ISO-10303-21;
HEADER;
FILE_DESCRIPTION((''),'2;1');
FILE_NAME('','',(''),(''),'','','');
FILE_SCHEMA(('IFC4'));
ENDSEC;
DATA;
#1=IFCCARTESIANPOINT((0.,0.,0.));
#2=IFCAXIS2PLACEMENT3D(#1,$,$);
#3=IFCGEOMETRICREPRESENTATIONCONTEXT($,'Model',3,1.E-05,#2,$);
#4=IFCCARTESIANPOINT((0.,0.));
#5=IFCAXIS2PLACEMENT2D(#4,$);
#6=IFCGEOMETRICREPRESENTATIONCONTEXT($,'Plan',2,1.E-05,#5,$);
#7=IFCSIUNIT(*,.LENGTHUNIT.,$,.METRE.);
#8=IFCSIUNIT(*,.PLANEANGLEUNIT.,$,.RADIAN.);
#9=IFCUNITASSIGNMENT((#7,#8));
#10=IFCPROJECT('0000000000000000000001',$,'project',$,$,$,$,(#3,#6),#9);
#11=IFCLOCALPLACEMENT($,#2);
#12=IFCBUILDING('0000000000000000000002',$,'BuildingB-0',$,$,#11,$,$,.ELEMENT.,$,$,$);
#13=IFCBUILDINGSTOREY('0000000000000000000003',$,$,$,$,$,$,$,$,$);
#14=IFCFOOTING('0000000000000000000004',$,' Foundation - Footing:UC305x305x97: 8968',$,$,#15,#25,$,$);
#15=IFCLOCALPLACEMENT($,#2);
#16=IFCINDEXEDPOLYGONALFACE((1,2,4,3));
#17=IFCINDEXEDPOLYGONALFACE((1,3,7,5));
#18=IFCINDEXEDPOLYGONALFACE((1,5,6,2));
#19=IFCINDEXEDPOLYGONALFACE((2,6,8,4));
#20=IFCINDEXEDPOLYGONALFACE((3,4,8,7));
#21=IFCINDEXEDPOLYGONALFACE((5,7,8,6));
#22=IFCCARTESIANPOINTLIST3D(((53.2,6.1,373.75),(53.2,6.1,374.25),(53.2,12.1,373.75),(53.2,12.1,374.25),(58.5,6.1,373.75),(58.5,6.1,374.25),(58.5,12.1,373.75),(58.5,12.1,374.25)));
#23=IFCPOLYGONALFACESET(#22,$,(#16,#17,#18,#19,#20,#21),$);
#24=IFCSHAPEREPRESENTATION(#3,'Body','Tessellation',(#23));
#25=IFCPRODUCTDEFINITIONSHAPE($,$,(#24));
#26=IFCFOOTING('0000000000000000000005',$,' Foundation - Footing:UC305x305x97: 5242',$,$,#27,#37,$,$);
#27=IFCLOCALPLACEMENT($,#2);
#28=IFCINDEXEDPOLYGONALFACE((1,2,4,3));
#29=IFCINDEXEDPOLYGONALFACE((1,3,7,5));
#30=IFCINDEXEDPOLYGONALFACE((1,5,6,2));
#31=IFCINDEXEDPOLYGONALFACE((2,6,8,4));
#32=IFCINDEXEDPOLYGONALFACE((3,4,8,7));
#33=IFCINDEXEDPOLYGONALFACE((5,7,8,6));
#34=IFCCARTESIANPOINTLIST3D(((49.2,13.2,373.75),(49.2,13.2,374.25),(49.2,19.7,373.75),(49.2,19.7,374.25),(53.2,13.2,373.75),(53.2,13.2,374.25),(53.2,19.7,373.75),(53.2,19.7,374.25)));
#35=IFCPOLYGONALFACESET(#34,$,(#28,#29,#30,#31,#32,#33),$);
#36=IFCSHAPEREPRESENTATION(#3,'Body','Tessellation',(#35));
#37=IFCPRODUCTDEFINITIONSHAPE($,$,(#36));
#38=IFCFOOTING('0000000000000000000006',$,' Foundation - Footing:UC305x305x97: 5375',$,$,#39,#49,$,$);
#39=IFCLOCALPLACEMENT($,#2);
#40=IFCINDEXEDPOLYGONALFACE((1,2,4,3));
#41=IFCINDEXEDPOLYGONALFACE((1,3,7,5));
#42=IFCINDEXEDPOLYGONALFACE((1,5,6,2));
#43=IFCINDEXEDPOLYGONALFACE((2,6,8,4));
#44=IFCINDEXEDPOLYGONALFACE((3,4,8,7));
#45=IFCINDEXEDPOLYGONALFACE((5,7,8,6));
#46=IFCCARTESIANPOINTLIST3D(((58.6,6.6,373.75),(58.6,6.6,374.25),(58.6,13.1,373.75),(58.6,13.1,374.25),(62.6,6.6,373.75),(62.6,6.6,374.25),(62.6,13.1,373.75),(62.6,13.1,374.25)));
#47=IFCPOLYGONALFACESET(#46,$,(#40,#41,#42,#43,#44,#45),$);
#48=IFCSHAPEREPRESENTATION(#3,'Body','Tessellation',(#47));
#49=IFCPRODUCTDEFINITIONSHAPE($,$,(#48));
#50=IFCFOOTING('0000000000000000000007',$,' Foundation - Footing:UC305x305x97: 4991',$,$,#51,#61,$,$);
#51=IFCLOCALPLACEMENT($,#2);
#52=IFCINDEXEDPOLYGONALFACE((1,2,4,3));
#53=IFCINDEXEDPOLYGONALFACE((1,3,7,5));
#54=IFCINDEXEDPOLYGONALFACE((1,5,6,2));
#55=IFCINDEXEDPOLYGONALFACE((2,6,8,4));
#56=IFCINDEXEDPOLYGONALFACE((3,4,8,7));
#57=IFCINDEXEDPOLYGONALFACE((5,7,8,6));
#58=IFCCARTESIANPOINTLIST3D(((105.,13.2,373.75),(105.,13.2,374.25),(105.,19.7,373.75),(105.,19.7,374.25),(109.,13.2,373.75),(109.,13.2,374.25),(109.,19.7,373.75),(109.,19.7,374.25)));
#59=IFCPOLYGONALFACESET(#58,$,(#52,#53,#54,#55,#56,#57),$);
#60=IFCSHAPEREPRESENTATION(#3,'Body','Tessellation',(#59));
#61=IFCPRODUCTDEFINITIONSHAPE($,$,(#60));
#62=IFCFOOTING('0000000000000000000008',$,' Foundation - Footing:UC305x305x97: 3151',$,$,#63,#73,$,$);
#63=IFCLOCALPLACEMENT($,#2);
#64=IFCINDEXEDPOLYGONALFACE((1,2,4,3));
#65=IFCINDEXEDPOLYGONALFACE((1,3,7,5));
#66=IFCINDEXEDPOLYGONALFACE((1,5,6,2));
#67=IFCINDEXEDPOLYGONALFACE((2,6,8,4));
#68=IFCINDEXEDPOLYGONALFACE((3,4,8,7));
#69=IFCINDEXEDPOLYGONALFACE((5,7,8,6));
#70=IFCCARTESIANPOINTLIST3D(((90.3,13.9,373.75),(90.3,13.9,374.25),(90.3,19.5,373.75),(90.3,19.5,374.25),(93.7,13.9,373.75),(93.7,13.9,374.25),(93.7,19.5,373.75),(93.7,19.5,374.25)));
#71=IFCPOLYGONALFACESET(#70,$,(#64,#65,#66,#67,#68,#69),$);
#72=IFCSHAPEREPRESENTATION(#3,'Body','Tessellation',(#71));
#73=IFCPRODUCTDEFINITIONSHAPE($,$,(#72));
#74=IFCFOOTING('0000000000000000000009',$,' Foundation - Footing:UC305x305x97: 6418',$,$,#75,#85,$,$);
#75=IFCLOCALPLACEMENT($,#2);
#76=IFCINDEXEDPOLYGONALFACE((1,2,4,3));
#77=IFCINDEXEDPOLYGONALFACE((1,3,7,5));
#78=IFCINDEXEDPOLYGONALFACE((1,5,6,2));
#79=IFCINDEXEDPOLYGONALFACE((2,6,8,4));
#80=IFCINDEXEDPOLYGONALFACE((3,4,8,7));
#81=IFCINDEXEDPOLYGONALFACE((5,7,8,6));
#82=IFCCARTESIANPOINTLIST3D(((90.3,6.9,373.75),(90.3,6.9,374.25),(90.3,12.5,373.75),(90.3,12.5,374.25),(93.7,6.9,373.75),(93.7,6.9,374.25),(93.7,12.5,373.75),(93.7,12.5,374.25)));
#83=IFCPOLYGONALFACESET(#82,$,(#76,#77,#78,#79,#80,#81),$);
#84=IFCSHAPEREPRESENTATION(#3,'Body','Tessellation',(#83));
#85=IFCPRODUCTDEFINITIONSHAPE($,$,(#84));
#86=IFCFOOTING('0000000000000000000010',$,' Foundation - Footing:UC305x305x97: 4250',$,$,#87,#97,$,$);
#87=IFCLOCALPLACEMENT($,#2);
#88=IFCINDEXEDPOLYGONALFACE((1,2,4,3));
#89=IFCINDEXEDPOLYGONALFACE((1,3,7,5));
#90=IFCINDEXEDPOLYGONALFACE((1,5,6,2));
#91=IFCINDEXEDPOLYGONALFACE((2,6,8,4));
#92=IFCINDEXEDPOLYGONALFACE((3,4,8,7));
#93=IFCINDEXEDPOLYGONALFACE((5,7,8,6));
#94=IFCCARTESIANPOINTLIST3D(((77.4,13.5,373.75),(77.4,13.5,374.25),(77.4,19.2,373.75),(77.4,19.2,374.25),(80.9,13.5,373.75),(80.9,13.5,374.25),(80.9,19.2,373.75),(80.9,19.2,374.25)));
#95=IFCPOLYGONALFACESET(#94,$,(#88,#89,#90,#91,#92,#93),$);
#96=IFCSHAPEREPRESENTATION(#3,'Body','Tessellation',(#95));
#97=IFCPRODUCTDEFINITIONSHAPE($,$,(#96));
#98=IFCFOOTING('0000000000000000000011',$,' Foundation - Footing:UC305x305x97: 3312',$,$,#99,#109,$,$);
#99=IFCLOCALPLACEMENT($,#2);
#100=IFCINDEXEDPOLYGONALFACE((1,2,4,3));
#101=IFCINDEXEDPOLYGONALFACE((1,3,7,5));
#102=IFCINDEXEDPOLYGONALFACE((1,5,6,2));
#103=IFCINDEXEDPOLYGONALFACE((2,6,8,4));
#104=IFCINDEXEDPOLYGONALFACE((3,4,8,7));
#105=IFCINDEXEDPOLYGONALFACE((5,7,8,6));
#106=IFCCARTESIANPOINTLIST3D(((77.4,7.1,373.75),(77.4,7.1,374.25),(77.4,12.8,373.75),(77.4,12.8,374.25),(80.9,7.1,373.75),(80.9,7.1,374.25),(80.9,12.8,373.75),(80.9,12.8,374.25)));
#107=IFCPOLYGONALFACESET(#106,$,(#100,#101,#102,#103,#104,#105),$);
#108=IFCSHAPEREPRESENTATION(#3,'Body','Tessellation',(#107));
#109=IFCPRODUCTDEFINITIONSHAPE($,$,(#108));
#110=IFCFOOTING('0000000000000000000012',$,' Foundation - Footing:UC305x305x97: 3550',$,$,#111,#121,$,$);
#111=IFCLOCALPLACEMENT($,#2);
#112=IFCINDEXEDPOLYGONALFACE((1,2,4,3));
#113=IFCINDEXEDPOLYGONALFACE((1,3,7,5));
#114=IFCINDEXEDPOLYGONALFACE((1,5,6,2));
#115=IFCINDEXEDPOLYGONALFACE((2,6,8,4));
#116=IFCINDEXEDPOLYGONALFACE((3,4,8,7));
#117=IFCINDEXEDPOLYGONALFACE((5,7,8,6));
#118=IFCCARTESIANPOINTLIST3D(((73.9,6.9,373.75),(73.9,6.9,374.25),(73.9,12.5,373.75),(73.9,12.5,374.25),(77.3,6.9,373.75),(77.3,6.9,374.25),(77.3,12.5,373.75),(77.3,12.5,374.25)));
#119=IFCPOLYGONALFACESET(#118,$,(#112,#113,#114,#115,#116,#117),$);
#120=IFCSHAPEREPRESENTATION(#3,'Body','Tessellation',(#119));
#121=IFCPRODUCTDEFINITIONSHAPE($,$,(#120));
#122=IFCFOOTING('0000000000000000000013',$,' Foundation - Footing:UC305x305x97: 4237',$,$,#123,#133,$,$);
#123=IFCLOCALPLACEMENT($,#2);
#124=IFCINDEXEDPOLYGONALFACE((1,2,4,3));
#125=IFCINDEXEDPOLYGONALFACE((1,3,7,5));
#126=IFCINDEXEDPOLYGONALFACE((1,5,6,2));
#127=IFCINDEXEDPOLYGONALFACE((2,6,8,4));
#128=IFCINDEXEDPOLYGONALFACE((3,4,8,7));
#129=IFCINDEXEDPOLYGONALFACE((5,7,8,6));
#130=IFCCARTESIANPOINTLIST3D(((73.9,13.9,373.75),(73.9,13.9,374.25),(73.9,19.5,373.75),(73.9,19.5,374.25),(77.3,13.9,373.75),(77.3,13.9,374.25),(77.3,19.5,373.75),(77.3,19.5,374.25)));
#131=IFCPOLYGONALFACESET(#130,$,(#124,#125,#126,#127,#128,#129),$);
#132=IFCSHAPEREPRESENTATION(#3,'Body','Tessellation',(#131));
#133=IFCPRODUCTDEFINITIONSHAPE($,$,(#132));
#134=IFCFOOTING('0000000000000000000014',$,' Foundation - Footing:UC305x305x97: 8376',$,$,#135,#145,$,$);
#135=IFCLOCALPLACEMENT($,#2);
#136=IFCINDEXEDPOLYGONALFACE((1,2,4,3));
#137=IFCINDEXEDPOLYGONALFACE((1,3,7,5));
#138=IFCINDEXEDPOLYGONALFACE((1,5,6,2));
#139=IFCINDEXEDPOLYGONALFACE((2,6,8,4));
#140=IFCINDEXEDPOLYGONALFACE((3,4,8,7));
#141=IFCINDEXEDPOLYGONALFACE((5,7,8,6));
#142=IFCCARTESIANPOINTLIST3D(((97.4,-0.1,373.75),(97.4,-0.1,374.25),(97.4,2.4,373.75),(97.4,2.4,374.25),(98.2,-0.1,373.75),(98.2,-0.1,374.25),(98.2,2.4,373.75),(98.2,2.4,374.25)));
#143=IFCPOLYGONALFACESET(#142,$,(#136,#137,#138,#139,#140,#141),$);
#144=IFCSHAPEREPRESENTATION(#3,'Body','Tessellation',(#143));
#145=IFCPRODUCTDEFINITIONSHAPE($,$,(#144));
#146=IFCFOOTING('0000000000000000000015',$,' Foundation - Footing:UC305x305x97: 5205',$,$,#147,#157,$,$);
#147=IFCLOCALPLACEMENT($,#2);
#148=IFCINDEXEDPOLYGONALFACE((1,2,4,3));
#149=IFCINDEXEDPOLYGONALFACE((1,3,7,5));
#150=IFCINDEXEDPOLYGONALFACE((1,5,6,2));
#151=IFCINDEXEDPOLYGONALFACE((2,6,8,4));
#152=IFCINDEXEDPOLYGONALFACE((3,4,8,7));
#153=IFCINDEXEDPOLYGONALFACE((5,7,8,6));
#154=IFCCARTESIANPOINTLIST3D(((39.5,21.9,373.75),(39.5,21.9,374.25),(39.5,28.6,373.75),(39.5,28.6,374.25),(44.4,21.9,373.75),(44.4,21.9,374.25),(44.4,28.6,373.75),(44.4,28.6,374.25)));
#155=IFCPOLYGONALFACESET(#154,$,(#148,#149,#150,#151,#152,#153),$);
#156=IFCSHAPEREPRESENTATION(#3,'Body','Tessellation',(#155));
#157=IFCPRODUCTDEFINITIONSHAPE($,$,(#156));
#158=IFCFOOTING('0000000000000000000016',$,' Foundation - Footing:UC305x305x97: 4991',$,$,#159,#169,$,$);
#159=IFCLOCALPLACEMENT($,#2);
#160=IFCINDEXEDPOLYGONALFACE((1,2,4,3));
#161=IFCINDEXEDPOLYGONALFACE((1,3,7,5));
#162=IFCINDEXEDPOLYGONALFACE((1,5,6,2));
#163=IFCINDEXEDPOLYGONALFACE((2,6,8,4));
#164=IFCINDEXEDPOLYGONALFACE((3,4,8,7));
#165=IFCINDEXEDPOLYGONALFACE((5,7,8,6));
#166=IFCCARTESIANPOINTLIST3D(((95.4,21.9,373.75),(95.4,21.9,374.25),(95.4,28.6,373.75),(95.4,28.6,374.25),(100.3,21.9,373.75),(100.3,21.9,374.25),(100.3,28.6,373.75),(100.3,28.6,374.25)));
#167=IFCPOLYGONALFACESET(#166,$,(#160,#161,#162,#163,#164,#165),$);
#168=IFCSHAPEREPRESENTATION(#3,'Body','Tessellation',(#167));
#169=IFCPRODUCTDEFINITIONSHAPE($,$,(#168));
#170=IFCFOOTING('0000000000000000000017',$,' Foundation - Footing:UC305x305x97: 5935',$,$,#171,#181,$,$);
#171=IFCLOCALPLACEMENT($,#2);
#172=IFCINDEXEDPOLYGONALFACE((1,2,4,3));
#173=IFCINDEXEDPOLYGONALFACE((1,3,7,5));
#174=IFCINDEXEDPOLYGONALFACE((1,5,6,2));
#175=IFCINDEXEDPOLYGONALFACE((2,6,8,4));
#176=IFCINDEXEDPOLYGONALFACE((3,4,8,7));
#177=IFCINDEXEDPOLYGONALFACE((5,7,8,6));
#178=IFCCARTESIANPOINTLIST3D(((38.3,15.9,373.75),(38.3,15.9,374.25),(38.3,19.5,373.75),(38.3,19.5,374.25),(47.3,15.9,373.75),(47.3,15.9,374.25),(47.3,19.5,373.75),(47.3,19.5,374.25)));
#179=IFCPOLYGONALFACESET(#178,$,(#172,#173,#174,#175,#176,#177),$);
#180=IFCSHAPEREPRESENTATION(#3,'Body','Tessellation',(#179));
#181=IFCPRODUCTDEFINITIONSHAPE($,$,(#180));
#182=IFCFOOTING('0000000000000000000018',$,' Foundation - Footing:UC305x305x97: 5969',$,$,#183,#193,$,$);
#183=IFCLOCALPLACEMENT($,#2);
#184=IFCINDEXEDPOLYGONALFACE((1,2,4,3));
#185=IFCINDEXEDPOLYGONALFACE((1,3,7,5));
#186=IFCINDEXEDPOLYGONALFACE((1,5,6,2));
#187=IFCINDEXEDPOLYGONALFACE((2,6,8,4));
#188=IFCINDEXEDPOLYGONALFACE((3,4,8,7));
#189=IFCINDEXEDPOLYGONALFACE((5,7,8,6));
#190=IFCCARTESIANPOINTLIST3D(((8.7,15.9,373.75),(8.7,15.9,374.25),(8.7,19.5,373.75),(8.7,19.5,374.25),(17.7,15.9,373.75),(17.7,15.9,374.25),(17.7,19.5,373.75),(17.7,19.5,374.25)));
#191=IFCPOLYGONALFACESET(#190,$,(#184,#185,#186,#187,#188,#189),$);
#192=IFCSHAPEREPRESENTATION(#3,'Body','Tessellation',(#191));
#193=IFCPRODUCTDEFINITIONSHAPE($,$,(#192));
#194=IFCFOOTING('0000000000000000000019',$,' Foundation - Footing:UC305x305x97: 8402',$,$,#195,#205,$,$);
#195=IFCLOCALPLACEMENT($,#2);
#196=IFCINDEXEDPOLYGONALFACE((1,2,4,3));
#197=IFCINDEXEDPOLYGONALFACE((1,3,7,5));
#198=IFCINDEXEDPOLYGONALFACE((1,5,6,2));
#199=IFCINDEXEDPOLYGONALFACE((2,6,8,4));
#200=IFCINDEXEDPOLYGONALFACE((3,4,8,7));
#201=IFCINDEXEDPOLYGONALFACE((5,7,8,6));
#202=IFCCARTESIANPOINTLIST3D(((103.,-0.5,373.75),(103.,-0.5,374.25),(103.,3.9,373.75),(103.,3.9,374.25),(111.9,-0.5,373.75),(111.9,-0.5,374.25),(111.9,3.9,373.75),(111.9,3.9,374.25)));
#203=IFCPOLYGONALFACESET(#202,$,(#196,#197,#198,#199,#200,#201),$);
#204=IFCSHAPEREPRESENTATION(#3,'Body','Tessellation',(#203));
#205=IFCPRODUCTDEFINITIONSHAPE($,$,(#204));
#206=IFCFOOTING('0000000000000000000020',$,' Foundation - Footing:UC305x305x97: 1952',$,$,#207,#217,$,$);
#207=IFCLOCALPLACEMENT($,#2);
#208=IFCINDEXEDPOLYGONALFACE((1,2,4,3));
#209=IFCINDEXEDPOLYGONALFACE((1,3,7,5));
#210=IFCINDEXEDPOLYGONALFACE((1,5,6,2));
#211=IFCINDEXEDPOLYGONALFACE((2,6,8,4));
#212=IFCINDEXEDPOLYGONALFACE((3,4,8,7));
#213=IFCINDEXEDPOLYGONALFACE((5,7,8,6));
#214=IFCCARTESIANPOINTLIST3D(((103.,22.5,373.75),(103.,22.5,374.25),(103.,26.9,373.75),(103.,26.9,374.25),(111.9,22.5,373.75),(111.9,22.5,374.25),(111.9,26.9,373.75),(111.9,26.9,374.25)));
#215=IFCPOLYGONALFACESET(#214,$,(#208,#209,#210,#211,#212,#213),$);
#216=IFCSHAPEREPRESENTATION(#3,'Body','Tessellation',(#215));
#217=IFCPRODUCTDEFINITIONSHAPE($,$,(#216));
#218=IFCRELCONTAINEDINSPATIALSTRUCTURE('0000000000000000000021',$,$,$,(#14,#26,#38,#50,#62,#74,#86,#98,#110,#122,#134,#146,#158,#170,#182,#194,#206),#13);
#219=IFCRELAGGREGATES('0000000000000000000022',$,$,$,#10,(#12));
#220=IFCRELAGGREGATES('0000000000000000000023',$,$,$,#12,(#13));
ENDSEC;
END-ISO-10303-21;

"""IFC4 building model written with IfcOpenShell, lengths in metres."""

from ifc_helpers import new_model, si_unit, origin, origin_2d, place, context, project, spatial, polyline, outline, extrude, element, save


model = new_model("IFC4")

# Units and contexts
model_context = context("Model", 3, precision=1e-05, world=origin())
plan_context = context("Plan", 2, precision=1e-05, world=origin_2d())
ifc_project = project(units=[si_unit("LENGTHUNIT", "METRE"), si_unit("PLANEANGLEUNIT", "RADIAN")], contexts=[model_context, plan_context])

# Building, storey
building_placement = place(None, origin())
building = spatial("IfcBuilding", under=ifc_project, at=building_placement, Name="BuildingB-0", CompositionType="ELEMENT")
storey = spatial("IfcBuildingStorey", under=building)

# Footings
element("IfcFooting", 1, inside=storey, Name=" Foundation - Footing:UC305x305x97: 8968", context=model_context, shape_type="SweptSolid", body=[
    extrude(outline(polyline([(58.5, 12.1, 373.75), (53.2, 12.1, 373.75), (53.2, 6.1, 373.75), (58.5, 6.1, 373.75), (58.5, 12.1, 373.75)])), None, (0.0, 0.0, 1.0), 0.5),
])
element("IfcFooting", 2, inside=storey, Name=" Foundation - Footing:UC305x305x97: 5242", context=model_context, shape_type="SweptSolid", body=[
    extrude(outline(polyline([(53.2, 19.7, 373.75), (49.2, 19.7, 373.75), (49.2, 13.2, 373.75), (53.2, 13.2, 373.75), (53.2, 19.7, 373.75)])), None, (0.0, 0.0, 1.0), 0.5),
])
element("IfcFooting", 3, inside=storey, Name=" Foundation - Footing:UC305x305x97: 5375", context=model_context, shape_type="SweptSolid", body=[
    extrude(outline(polyline([(58.6, 13.1, 373.75), (62.6, 13.1, 373.75), (62.6, 6.6, 373.75), (58.6, 6.6, 373.75), (58.6, 13.1, 373.75)])), None, (0.0, 0.0, 1.0), 0.5),
])
element("IfcFooting", 4, inside=storey, Name=" Foundation - Footing:UC305x305x97: 4991", context=model_context, shape_type="SweptSolid", body=[
    extrude(outline(polyline([(109.0, 19.7, 373.75), (105.0, 19.7, 373.75), (105.0, 13.2, 373.75), (109.0, 13.2, 373.75), (109.0, 19.7, 373.75)])), None, (0.0, 0.0, 1.0), 0.5),
])
element("IfcFooting", 5, inside=storey, Name=" Foundation - Footing:UC305x305x97: 3151", context=model_context, shape_type="SweptSolid", body=[
    extrude(outline(polyline([(90.3, 19.5, 373.75), (93.7, 19.5, 373.75), (93.7, 13.9, 373.75), (90.3, 13.9, 373.75), (90.3, 19.5, 373.75)])), None, (0.0, 0.0, 1.0), 0.5),
])
element("IfcFooting", 6, inside=storey, Name=" Foundation - Footing:UC305x305x97: 6418", context=model_context, shape_type="SweptSolid", body=[
    extrude(outline(polyline([(90.3, 12.5, 373.75), (93.7, 12.5, 373.75), (93.7, 6.9, 373.75), (90.3, 6.9, 373.75), (90.3, 12.5, 373.75)])), None, (0.0, 0.0, 1.0), 0.5),
])
element("IfcFooting", 7, inside=storey, Name=" Foundation - Footing:UC305x305x97: 4250", context=model_context, shape_type="SweptSolid", body=[
    extrude(outline(polyline([(77.4, 19.2, 373.75), (80.9, 19.2, 373.75), (80.9, 13.5, 373.75), (77.4, 13.5, 373.75), (77.4, 19.2, 373.75)])), None, (0.0, 0.0, 1.0), 0.5),
])
element("IfcFooting", 8, inside=storey, Name=" Foundation - Footing:UC305x305x97: 3312", context=model_context, shape_type="SweptSolid", body=[
    extrude(outline(polyline([(77.4, 12.8, 373.75), (80.9, 12.8, 373.75), (80.9, 7.1, 373.75), (77.4, 7.1, 373.75), (77.4, 12.8, 373.75)])), None, (0.0, 0.0, 1.0), 0.5),
])
element("IfcFooting", 9, inside=storey, Name=" Foundation - Footing:UC305x305x97: 3550", context=model_context, shape_type="SweptSolid", body=[
    extrude(outline(polyline([(73.9, 12.5, 373.75), (77.3, 12.5, 373.75), (77.3, 6.9, 373.75), (73.9, 6.9, 373.75), (73.9, 12.5, 373.75)])), None, (0.0, 0.0, 1.0), 0.5),
])
element("IfcFooting", 10, inside=storey, Name=" Foundation - Footing:UC305x305x97: 4237", context=model_context, shape_type="SweptSolid", body=[
    extrude(outline(polyline([(73.9, 19.5, 373.75), (77.3, 19.5, 373.75), (77.3, 13.9, 373.75), (73.9, 13.9, 373.75), (73.9, 19.5, 373.75)])), None, (0.0, 0.0, 1.0), 0.5),
])
element("IfcFooting", 11, inside=storey, Name=" Foundation - Footing:UC305x305x97: 8376", context=model_context, shape_type="SweptSolid", body=[
    extrude(outline(polyline([(97.4, 2.4, 373.75), (98.2, 2.4, 373.75), (98.2, -0.1, 373.75), (97.4, -0.1, 373.75), (97.4, 2.4, 373.75)])), None, (0.0, 0.0, 1.0), 0.5),
])
element("IfcFooting", 12, inside=storey, Name=" Foundation - Footing:UC305x305x97: 5205", context=model_context, shape_type="SweptSolid", body=[
    extrude(outline(polyline([(44.4, 21.9, 373.75), (44.4, 28.6, 373.75), (39.5, 28.6, 373.75), (39.5, 21.9, 373.75), (44.4, 21.9, 373.75)])), None, (0.0, 0.0, 1.0), 0.5),
])
element("IfcFooting", 13, inside=storey, Name=" Foundation - Footing:UC305x305x97: 4991", context=model_context, shape_type="SweptSolid", body=[
    extrude(outline(polyline([(95.4, 21.9, 373.75), (95.4, 28.6, 373.75), (100.3, 28.6, 373.75), (100.3, 21.9, 373.75), (95.4, 21.9, 373.75)])), None, (0.0, 0.0, 1.0), 0.5),
])
element("IfcFooting", 14, inside=storey, Name=" Foundation - Footing:UC305x305x97: 5935", context=model_context, shape_type="SweptSolid", body=[
    extrude(outline(polyline([(47.3, 19.5, 373.75), (38.3, 19.5, 373.75), (38.3, 15.9, 373.75), (47.3, 15.9, 373.75), (47.3, 19.5, 373.75)])), None, (0.0, 0.0, 1.0), 0.5),
])
element("IfcFooting", 15, inside=storey, Name=" Foundation - Footing:UC305x305x97: 5969", context=model_context, shape_type="SweptSolid", body=[
    extrude(outline(polyline([(17.7, 19.5, 373.75), (8.7, 19.5, 373.75), (8.7, 15.9, 373.75), (17.7, 15.9, 373.75), (17.7, 19.5, 373.75)])), None, (0.0, 0.0, 1.0), 0.5),
])
element("IfcFooting", 16, inside=storey, Name=" Foundation - Footing:UC305x305x97: 8402", context=model_context, shape_type="SweptSolid", body=[
    extrude(outline(polyline([(111.9, 3.9, 373.75), (103.0, 3.9, 373.75), (103.0, -0.5, 373.75), (111.9, -0.5, 373.75), (111.9, 3.9, 373.75)])), None, (0.0, 0.0, 1.0), 0.5),
])
element("IfcFooting", 17, inside=storey, Name=" Foundation - Footing:UC305x305x97: 1952", context=model_context, shape_type="SweptSolid", body=[
    extrude(outline(polyline([(111.9, 26.9, 373.75), (103.0, 26.9, 373.75), (103.0, 22.5, 373.75), (111.9, 22.5, 373.75), (111.9, 26.9, 373.75)])), None, (0.0, 0.0, 1.0), 0.5),
])

save(model, "model.ifc")
